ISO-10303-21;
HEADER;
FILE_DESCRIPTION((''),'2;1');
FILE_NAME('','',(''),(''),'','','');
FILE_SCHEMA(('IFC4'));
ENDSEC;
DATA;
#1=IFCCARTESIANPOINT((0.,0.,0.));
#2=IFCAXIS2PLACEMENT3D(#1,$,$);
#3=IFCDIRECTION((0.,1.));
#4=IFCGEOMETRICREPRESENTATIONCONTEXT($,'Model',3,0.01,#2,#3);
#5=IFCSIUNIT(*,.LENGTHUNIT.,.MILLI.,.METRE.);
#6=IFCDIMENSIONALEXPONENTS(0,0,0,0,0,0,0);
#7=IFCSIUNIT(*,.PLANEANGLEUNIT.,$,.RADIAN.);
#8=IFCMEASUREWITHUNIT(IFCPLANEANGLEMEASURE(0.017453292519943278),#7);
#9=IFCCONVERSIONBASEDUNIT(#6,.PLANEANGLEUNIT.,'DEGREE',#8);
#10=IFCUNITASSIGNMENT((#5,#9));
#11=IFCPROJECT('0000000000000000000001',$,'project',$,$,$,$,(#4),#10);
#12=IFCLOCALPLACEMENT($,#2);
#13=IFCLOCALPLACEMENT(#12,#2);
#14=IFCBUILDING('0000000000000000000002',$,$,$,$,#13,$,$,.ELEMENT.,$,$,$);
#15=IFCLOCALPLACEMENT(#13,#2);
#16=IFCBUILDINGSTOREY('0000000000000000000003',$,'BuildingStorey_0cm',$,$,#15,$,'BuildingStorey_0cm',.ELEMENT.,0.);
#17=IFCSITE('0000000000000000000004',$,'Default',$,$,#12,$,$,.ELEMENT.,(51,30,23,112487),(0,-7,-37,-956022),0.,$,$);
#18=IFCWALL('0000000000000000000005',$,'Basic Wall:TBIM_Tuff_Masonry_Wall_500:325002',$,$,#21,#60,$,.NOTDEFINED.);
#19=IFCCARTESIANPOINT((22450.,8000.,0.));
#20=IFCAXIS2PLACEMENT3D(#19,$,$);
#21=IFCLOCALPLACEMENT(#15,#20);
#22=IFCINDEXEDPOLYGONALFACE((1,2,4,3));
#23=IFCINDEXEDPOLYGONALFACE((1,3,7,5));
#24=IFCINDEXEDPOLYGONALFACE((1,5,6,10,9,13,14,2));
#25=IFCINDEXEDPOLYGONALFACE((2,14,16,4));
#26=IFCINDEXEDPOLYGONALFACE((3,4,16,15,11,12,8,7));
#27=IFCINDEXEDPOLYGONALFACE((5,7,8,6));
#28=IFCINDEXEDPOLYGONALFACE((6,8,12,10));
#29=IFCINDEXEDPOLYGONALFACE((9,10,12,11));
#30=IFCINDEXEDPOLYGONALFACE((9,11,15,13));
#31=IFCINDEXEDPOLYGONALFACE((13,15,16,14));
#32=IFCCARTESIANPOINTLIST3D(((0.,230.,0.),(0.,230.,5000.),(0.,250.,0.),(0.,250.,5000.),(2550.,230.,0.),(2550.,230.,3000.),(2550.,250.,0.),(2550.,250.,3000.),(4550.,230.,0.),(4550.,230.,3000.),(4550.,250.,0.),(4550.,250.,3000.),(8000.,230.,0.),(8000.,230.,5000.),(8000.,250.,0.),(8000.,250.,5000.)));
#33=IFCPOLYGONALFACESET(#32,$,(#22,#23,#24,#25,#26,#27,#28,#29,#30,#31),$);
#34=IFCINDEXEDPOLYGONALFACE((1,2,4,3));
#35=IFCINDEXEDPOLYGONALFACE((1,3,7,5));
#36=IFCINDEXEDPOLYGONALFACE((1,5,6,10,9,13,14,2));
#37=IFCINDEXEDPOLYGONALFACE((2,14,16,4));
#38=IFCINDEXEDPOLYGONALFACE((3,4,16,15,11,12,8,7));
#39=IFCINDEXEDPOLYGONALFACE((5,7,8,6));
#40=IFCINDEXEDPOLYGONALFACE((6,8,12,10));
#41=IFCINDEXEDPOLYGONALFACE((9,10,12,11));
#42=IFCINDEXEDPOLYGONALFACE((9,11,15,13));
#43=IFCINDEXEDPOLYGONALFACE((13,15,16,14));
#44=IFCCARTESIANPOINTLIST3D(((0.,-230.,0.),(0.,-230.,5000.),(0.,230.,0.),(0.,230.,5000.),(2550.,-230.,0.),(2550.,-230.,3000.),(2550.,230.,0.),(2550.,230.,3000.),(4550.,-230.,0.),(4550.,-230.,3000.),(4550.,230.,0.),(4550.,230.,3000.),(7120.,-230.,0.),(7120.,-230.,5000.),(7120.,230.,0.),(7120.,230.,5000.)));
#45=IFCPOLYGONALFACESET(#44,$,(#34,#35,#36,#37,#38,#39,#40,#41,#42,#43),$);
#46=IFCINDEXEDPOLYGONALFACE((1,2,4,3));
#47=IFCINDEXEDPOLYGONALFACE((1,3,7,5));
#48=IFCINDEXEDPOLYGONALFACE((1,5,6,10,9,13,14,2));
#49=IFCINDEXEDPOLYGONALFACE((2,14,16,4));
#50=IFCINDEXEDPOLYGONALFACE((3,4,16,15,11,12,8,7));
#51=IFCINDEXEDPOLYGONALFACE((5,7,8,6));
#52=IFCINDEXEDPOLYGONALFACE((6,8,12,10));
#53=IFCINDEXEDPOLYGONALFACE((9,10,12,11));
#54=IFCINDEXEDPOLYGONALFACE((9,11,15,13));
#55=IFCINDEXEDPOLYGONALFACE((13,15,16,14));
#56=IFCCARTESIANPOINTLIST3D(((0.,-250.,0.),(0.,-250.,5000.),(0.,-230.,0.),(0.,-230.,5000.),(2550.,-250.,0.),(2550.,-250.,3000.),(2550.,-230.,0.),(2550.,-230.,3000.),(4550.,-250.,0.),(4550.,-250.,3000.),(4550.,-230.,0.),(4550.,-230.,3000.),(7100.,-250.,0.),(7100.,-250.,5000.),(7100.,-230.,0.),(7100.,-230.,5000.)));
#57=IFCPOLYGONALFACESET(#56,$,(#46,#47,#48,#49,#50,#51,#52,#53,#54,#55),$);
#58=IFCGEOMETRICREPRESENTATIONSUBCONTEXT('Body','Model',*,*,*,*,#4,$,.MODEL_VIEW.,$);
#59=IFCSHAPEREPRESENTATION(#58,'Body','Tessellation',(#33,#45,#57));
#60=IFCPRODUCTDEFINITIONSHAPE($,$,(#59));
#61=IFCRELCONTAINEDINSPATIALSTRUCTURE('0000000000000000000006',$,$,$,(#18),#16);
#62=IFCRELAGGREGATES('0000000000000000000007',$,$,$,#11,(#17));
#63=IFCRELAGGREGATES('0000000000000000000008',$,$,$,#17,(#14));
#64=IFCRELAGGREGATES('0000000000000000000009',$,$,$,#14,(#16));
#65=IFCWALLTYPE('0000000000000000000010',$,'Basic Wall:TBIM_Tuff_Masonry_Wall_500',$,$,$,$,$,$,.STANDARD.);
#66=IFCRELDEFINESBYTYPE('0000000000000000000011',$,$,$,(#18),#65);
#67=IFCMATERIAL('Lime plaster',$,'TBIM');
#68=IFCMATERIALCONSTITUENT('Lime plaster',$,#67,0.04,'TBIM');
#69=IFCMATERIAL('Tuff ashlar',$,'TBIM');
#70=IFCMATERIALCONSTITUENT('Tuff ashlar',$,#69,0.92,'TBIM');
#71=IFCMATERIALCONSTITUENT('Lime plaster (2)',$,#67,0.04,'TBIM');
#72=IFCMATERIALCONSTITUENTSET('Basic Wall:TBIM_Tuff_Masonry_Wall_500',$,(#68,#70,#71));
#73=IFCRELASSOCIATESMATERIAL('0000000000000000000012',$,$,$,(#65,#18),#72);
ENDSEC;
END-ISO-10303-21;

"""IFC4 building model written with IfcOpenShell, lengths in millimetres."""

from ifc_helpers import new_model, entity, si_unit, converted_unit, direction, frame, origin, place, context, subcontext, project, spatial, indexed_curve, outline, extrude, material, constituent, constituent_set, type_object, element, save


model = new_model("IFC4")

# Units and contexts
model_context = context("Model", 3, precision=0.01, world=origin(), true_north=direction((0.0, 1.0)))
body_context = subcontext(model_context, "Body", "Model", "MODEL_VIEW")
ifc_project = project(units=[si_unit("LENGTHUNIT", "METRE", prefix="MILLI"), converted_unit("PLANEANGLEUNIT", "DEGREE", entity("IfcPlaneAngleMeasure", 0.017453292519943278), si_unit("PLANEANGLEUNIT", "RADIAN"), dimensions=[0, 0, 0, 0, 0, 0, 0])], contexts=[model_context])

# Site, building, storey
site_placement = place(None, origin())
site = spatial("IfcSite", under=ifc_project, at=site_placement, Name="Default", CompositionType="ELEMENT", RefLatitude=(51, 30, 23, 112487), RefLongitude=(0, -7, -37, -956022), RefElevation=0.0)
building_placement = place(site_placement, origin())
building = spatial("IfcBuilding", under=site, at=building_placement, CompositionType="ELEMENT")
storey_placement = place(building_placement, origin())
storey = spatial("IfcBuildingStorey", under=building, at=storey_placement, Name="BuildingStorey_0cm", LongName="BuildingStorey_0cm", CompositionType="ELEMENT", Elevation=0.0)

# Shared definitions
ifc_material_1 = material(Name="Tuff ashlar", Category="TBIM")
ifc_material_2 = material(Name="Lime plaster", Category="TBIM")

# Shared definitions
ifc_constituent_1 = constituent(ifc_material_2, Name="Lime plaster", Category="TBIM", fraction=0.04)
ifc_constituent_2 = constituent(ifc_material_1, Name="Tuff ashlar", Category="TBIM", fraction=0.92)
ifc_constituent_3 = constituent(ifc_material_2, Name="Lime plaster (2)", Category="TBIM", fraction=0.04)
ifc_constituent_set_1 = constituent_set(constituents=[ifc_constituent_1, ifc_constituent_2, ifc_constituent_3], Name="Basic Wall:TBIM_Tuff_Masonry_Wall_500")
wall_type_1 = type_object("IfcWallType", Name="Basic Wall:TBIM_Tuff_Masonry_Wall_500", PredefinedType="STANDARD", material=ifc_constituent_set_1)

# Wall, opening
wall_1_placement = place(storey_placement, frame((22450.0, 8000.0, 0.0)))
wall_1 = element("IfcWall", 1, at=wall_1_placement, inside=storey, type_object=wall_type_1, material=ifc_constituent_set_1, Name="Basic Wall:TBIM_Tuff_Masonry_Wall_500:325002", PredefinedType="NOTDEFINED", context=body_context, shape_type="SweptSolid", body=[
    extrude(outline(indexed_curve([(-2000.0, -3775.0), (3000.0, -3775.0), (3000.0, 4225.0), (-2000.0, 4225.0), (-2000.0, 775.0), (1000.0, 775.0), (1000.0, -1225.0), (-2000.0, -1225.0), (-2000.0, -3775.0)], self_intersect=False)), frame((3775.0, 230.0, 2000.0), z_axis=(0.0, 1.0, 0.0), x_axis=(0.0, 0.0, 1.0)), (0.0, 0.0, 1.0), 20.0),
    extrude(outline(indexed_curve([(-2000.0, -3555.0), (3000.0, -3555.0), (3000.0, 3565.0), (-2000.0, 3565.0), (-2000.0, 995.0), (1000.0, 995.0), (1000.0, -1005.0), (-2000.0, -1005.0), (-2000.0, -3555.0)], self_intersect=False)), frame((3555.0, -230.0, 2000.0), z_axis=(0.0, 1.0, 0.0), x_axis=(0.0, 0.0, 1.0)), (0.0, 0.0, 1.0), 460.0),
    extrude(outline(indexed_curve([(-1000.0, -1000.0), (-1000.0, 2000.0), (-3550.0, 2000.0), (-3550.0, -3000.0), (3550.0, -3000.0), (3550.0, 2000.0), (1000.0, 2000.0), (1000.0, -1000.0), (-1000.0, -1000.0)], self_intersect=False)), frame((3550.0, -250.0, 2000.0), z_axis=(0.0, -1.0, 0.0), x_axis=(-1.0, 0.0, 0.0)), (0.0, 0.0, -1.0), 20.0),
])
opening_1_placement = place(wall_1_placement, frame((4550.0, 250.0, 0.0)))
element("IfcOpeningElement", 2, at=opening_1_placement, cuts=wall_1, PredefinedType="OPENING", context=body_context, shape_type="SweptSolid", body=[
    extrude(outline(indexed_curve([(3000.0, 2000.0), (0.0, 2000.0), (0.0, 0.0), (3000.0, 0.0), (3000.0, 2000.0)], self_intersect=False)), frame((0.0, 0.0, 0.0), z_axis=(0.0, -1.0, 0.0), x_axis=(0.0, 0.0, 1.0)), (0.0, 0.0, 1.0), 500.0),
])

save(model, "model.ifc")
